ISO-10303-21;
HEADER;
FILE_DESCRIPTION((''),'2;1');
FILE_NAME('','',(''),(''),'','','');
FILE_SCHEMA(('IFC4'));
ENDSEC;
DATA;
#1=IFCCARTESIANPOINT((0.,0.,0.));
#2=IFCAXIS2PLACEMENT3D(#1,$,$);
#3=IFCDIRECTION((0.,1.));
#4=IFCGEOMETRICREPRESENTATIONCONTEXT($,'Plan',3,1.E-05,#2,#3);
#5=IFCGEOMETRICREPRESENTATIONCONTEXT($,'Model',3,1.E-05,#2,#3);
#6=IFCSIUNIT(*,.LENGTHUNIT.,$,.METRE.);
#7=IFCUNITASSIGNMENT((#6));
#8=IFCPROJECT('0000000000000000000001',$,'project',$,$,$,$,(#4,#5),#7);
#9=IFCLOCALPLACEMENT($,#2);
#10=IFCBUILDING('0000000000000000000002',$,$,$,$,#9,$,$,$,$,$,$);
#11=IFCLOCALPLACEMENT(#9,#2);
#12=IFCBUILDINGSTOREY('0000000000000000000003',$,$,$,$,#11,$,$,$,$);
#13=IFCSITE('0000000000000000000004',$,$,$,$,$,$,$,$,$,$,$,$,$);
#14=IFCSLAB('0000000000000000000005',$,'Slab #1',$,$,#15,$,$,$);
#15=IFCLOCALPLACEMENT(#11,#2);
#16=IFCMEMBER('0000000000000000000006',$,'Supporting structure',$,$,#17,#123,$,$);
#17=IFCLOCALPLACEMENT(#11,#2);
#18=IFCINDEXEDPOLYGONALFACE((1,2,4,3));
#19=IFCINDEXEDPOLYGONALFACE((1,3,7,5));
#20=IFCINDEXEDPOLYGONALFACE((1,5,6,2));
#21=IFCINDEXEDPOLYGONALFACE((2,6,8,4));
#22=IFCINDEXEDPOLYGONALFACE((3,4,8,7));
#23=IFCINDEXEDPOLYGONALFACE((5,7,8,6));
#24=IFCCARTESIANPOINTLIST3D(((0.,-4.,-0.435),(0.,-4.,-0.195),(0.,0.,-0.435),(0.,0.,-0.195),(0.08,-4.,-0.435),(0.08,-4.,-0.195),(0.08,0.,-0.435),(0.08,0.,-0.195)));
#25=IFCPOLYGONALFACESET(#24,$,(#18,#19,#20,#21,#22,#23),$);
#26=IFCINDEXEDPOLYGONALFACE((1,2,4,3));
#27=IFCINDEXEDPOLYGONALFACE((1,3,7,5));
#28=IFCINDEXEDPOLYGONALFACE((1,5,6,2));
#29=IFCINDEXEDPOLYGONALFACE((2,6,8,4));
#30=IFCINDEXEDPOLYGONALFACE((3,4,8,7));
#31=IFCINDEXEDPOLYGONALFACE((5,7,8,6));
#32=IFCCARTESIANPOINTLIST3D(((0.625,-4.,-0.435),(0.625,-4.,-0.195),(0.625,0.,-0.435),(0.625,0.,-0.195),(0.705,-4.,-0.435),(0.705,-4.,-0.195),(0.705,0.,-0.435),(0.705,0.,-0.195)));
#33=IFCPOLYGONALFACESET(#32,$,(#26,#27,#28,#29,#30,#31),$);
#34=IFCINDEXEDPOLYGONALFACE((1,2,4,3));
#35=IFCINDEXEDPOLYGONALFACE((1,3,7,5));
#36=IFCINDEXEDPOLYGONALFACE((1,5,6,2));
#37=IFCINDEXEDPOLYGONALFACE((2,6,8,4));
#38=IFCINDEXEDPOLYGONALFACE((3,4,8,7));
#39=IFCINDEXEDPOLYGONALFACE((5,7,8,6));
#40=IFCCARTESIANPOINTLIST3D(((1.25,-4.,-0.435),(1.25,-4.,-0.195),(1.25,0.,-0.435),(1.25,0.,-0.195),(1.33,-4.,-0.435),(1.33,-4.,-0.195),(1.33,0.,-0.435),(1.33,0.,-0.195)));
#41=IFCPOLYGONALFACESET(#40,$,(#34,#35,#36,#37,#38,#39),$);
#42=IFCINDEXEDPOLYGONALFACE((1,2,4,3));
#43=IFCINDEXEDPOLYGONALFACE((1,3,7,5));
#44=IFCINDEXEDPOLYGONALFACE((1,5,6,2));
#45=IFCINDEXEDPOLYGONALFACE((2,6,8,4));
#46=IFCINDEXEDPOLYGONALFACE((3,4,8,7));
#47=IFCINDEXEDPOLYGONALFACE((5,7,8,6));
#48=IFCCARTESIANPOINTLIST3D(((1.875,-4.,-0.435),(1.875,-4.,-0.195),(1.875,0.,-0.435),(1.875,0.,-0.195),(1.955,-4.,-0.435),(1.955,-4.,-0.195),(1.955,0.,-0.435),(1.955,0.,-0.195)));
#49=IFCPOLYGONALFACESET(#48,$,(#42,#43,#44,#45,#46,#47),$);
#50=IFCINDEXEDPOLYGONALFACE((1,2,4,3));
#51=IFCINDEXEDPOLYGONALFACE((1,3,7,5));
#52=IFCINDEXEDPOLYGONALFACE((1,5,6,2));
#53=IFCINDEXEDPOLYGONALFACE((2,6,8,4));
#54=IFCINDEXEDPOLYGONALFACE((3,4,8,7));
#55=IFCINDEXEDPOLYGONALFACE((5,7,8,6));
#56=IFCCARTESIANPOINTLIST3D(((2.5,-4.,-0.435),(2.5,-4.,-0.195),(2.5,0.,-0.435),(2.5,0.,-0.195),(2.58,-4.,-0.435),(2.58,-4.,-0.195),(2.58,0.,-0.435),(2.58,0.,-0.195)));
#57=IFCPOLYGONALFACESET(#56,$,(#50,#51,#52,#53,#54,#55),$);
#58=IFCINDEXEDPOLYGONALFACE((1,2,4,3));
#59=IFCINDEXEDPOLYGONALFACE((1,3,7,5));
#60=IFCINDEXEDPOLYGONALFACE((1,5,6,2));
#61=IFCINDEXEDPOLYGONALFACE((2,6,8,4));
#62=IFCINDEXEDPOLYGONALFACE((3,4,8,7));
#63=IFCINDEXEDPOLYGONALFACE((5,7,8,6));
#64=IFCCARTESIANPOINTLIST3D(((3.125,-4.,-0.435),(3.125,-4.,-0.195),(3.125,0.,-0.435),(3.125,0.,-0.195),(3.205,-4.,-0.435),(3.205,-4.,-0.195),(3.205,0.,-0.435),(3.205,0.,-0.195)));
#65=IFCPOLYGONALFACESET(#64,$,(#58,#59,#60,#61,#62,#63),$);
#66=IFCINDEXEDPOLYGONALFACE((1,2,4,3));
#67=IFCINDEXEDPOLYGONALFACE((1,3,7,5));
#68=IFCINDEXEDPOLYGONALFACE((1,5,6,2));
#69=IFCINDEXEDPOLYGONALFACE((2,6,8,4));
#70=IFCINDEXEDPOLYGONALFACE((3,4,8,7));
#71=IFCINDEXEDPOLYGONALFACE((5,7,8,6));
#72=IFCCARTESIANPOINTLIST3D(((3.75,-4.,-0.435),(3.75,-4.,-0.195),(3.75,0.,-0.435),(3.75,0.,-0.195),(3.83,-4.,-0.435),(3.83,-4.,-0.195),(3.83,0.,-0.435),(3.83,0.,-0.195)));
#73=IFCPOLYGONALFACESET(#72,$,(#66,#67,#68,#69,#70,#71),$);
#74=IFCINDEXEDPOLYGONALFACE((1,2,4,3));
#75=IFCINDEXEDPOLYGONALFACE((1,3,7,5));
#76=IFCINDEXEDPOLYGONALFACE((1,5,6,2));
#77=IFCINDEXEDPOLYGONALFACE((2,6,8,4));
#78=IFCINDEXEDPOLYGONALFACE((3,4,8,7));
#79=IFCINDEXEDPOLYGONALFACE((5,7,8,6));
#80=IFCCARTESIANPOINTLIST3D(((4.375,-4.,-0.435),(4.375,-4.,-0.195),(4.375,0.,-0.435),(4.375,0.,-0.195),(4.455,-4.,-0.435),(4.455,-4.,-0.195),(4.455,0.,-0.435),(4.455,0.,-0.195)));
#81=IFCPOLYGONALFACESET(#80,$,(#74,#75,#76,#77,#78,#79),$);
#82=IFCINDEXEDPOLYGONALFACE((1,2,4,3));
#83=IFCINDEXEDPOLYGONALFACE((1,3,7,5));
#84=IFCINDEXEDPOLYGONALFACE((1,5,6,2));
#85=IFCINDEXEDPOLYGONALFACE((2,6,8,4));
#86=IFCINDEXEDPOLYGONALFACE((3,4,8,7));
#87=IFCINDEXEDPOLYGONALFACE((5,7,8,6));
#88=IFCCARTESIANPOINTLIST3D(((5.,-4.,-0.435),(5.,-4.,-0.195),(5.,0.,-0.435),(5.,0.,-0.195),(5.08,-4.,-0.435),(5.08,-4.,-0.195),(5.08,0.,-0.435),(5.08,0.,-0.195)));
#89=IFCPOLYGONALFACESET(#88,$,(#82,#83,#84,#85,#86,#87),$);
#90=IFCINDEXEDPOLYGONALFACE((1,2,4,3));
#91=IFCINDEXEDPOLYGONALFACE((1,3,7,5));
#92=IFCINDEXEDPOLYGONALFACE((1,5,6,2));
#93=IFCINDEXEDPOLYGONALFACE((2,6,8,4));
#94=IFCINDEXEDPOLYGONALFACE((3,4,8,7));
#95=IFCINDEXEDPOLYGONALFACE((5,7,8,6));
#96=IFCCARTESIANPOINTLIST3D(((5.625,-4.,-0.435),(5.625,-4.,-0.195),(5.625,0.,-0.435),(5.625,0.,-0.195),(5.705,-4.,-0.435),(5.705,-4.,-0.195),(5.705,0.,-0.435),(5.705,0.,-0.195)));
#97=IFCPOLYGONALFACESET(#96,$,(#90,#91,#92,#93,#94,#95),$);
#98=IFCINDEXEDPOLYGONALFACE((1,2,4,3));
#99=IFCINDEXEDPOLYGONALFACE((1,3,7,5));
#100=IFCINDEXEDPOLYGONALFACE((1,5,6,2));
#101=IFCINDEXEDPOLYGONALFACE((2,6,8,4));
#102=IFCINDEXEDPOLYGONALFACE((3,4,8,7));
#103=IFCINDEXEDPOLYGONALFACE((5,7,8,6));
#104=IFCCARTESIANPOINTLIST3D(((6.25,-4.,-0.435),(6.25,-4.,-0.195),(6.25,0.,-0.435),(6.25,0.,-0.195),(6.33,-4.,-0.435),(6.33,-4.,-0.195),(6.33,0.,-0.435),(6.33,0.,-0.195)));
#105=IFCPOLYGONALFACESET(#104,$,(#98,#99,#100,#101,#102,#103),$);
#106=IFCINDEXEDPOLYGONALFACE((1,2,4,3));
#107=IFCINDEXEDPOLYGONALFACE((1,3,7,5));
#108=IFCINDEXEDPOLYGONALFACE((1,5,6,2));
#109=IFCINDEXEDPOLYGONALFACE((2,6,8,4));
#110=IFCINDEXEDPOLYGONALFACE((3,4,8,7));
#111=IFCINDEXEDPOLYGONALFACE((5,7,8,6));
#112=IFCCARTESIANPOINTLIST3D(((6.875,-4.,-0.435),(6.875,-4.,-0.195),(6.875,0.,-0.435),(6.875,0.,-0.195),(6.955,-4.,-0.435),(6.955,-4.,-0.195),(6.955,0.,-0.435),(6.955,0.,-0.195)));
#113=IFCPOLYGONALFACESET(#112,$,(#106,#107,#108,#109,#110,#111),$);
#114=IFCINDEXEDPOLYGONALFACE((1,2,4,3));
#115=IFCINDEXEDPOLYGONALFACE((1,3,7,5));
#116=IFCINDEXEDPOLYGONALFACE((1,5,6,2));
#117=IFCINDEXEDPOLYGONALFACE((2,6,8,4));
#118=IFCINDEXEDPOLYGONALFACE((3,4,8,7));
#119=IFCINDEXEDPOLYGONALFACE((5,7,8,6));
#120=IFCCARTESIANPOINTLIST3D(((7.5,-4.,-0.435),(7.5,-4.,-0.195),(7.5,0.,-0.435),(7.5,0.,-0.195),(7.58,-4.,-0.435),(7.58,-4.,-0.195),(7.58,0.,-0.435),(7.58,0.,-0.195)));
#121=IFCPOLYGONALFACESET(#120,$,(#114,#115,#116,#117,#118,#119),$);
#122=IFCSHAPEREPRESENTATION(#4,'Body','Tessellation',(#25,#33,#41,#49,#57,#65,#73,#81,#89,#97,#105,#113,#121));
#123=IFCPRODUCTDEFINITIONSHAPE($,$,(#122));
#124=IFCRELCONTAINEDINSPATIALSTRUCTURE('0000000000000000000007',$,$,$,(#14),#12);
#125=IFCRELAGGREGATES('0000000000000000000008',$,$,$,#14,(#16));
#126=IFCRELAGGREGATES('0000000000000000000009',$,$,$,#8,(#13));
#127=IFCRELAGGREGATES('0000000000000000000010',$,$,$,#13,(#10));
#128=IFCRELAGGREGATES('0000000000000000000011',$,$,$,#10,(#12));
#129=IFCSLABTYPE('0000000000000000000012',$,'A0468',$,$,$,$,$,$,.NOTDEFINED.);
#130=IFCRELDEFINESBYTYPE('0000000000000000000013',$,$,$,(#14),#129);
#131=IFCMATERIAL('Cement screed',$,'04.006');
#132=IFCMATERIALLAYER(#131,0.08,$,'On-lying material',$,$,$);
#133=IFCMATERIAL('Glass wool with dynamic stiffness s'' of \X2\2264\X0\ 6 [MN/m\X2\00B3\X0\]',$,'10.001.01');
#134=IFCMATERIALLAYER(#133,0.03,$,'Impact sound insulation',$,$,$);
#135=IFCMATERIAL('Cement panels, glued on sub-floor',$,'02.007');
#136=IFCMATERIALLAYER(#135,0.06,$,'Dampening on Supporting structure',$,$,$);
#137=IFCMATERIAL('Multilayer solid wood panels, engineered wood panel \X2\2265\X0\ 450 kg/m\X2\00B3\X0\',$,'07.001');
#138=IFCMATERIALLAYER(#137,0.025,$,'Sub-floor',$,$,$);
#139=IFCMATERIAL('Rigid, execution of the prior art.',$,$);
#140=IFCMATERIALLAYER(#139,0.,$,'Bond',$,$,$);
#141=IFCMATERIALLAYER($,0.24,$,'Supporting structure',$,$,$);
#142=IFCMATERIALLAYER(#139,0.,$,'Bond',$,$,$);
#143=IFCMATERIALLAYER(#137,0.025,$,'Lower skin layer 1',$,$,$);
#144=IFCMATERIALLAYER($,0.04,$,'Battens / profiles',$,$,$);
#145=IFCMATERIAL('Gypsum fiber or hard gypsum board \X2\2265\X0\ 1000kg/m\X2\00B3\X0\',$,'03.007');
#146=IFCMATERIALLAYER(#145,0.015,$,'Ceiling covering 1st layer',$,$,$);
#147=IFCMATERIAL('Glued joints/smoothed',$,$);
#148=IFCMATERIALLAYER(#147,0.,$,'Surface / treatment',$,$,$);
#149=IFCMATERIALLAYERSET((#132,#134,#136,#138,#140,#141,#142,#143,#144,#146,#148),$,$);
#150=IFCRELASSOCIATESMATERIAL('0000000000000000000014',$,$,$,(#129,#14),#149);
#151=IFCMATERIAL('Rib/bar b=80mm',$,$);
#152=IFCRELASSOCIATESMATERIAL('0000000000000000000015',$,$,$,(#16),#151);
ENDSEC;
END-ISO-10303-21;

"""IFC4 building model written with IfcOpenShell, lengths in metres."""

from ifc_helpers import new_model, si_unit, direction, frame, frame_2d, origin, place, context, project, spatial, rectangle, extrude, material, layer, layer_set, type_object, element, aggregate, save


model = new_model("IFC4")

# Units and contexts
plan_context = context("Plan", 3, precision=1e-05, world=origin(), true_north=direction((0.0, 1.0)))
model_context = context("Model", 3, precision=1e-05, world=origin(), true_north=direction((0.0, 1.0)))
ifc_project = project(units=[si_unit("LENGTHUNIT", "METRE")], contexts=[plan_context, model_context])

# Site, building, storey
site = spatial("IfcSite", under=ifc_project)
building_placement = place(None, origin())
building = spatial("IfcBuilding", under=site, at=building_placement)
storey_placement = place(building_placement, origin())
storey = spatial("IfcBuildingStorey", under=building, at=storey_placement)

# Slab, member
ifc_material_1 = material(Name="Cement screed", Category="04.006")
ifc_layer_1 = layer(ifc_material_1, 0.08, Name="On-lying material")
ifc_material_2 = material(Name="Glass wool with dynamic stiffness s' of ≤ 6 [MN/m³]", Category="10.001.01")
ifc_layer_2 = layer(ifc_material_2, 0.03, Name="Impact sound insulation")
ifc_material_3 = material(Name="Cement panels, glued on sub-floor", Category="02.007")
ifc_layer_3 = layer(ifc_material_3, 0.06, Name="Dampening on Supporting structure")
ifc_material_4 = material(Name="Multilayer solid wood panels, engineered wood panel ≥ 450 kg/m³", Category="07.001")
ifc_layer_4 = layer(ifc_material_4, 0.025, Name="Sub-floor")
ifc_material_5 = material(Name="Rigid, execution of the prior art.")
ifc_layer_5 = layer(ifc_material_5, 0.0, Name="Bond")
ifc_layer_6 = layer(None, 0.24, Name="Supporting structure")
ifc_layer_7 = layer(ifc_material_5, 0.0, Name="Bond")
ifc_layer_8 = layer(ifc_material_4, 0.025, Name="Lower skin layer 1")
ifc_layer_9 = layer(None, 0.04, Name="Battens / profiles")
ifc_material_6 = material(Name="Gypsum fiber or hard gypsum board ≥ 1000kg/m³", Category="03.007")
ifc_layer_10 = layer(ifc_material_6, 0.015, Name="Ceiling covering 1st layer")
ifc_material_7 = material(Name="Glued joints/smoothed")
ifc_layer_11 = layer(ifc_material_7, 0.0, Name="Surface / treatment")
ifc_layer_set = layer_set([ifc_layer_1, ifc_layer_2, ifc_layer_3, ifc_layer_4, ifc_layer_5, ifc_layer_6, ifc_layer_7, ifc_layer_8, ifc_layer_9, ifc_layer_10, ifc_layer_11])
slab_type = type_object("IfcSlabType", Name="A0468", PredefinedType="NOTDEFINED", material=ifc_layer_set)
slab_placement = place(None, frame((0.0, 0.0, 0.0), z_axis=(0.0, 0.0, -1.0), x_axis=(1.0, 0.0, 0.0)))
slab = element("IfcSlab", 1, at=slab_placement, inside=storey, type_object=slab_type, material=ifc_layer_set, Name="Slab #1")
ifc_material_8 = material(Name="Rib/bar b=80mm")
member_1_placement = place(slab_placement, origin())
member_1 = element("IfcMember", 2, at=member_1_placement, material=ifc_material_8, Name="Supporting structure", context=plan_context, shape_type="SweptSolid", body=[
    extrude(rectangle(XDim=0.08, YDim=0.24, at=frame_2d((0.04, 0.12), x_axis=(1.0, 0.0))), frame((0.0, 4.0, 0.195), z_axis=(0.0, -1.0, 0.0), x_axis=(1.0, 0.0, 0.0)), (0.0, 0.0, 1.0), 4.0),
    extrude(rectangle(XDim=0.08, YDim=0.24, at=frame_2d((0.04, 0.12), x_axis=(1.0, 0.0))), frame((0.625, 4.0, 0.195), z_axis=(0.0, -1.0, 0.0), x_axis=(1.0, 0.0, 0.0)), (0.0, 0.0, 1.0), 4.0),
    extrude(rectangle(XDim=0.08, YDim=0.24, at=frame_2d((0.04, 0.12), x_axis=(1.0, 0.0))), frame((1.25, 4.0, 0.195), z_axis=(0.0, -1.0, 0.0), x_axis=(1.0, 0.0, 0.0)), (0.0, 0.0, 1.0), 4.0),
    extrude(rectangle(XDim=0.08, YDim=0.24, at=frame_2d((0.04, 0.12), x_axis=(1.0, 0.0))), frame((1.875, 4.0, 0.195), z_axis=(0.0, -1.0, 0.0), x_axis=(1.0, 0.0, 0.0)), (0.0, 0.0, 1.0), 4.0),
    extrude(rectangle(XDim=0.08, YDim=0.24, at=frame_2d((0.04, 0.12), x_axis=(1.0, 0.0))), frame((2.5, 4.0, 0.195), z_axis=(0.0, -1.0, 0.0), x_axis=(1.0, 0.0, 0.0)), (0.0, 0.0, 1.0), 4.0),
    extrude(rectangle(XDim=0.08, YDim=0.24, at=frame_2d((0.04, 0.12), x_axis=(1.0, 0.0))), frame((3.125, 4.0, 0.195), z_axis=(0.0, -1.0, 0.0), x_axis=(1.0, 0.0, 0.0)), (0.0, 0.0, 1.0), 4.0),
    extrude(rectangle(XDim=0.08, YDim=0.24, at=frame_2d((0.04, 0.12), x_axis=(1.0, 0.0))), frame((3.75, 4.0, 0.195), z_axis=(0.0, -1.0, 0.0), x_axis=(1.0, 0.0, 0.0)), (0.0, 0.0, 1.0), 4.0),
    extrude(rectangle(XDim=0.08, YDim=0.24, at=frame_2d((0.04, 0.12), x_axis=(1.0, 0.0))), frame((4.375, 4.0, 0.195), z_axis=(0.0, -1.0, 0.0), x_axis=(1.0, 0.0, 0.0)), (0.0, 0.0, 1.0), 4.0),
    extrude(rectangle(XDim=0.08, YDim=0.24, at=frame_2d((0.04, 0.12), x_axis=(1.0, 0.0))), frame((5.0, 4.0, 0.195), z_axis=(0.0, -1.0, 0.0), x_axis=(1.0, 0.0, 0.0)), (0.0, 0.0, 1.0), 4.0),
    extrude(rectangle(XDim=0.08, YDim=0.24, at=frame_2d((0.04, 0.12), x_axis=(1.0, 0.0))), frame((5.625, 4.0, 0.195), z_axis=(0.0, -1.0, 0.0), x_axis=(1.0, 0.0, 0.0)), (0.0, 0.0, 1.0), 4.0),
    extrude(rectangle(XDim=0.08, YDim=0.24, at=frame_2d((0.04, 0.12), x_axis=(1.0, 0.0))), frame((6.25, 4.0, 0.195), z_axis=(0.0, -1.0, 0.0), x_axis=(1.0, 0.0, 0.0)), (0.0, 0.0, 1.0), 4.0),
    extrude(rectangle(XDim=0.08, YDim=0.24, at=frame_2d((0.04, 0.12), x_axis=(1.0, 0.0))), frame((6.875, 4.0, 0.195), z_axis=(0.0, -1.0, 0.0), x_axis=(1.0, 0.0, 0.0)), (0.0, 0.0, 1.0), 4.0),
    extrude(rectangle(XDim=0.08, YDim=0.24, at=frame_2d((0.04, 0.12), x_axis=(1.0, 0.0))), frame((7.5, 4.0, 0.195), z_axis=(0.0, -1.0, 0.0), x_axis=(1.0, 0.0, 0.0)), (0.0, 0.0, 1.0), 4.0),
])
aggregate(slab, [member_1])

save(model, "model.ifc")
